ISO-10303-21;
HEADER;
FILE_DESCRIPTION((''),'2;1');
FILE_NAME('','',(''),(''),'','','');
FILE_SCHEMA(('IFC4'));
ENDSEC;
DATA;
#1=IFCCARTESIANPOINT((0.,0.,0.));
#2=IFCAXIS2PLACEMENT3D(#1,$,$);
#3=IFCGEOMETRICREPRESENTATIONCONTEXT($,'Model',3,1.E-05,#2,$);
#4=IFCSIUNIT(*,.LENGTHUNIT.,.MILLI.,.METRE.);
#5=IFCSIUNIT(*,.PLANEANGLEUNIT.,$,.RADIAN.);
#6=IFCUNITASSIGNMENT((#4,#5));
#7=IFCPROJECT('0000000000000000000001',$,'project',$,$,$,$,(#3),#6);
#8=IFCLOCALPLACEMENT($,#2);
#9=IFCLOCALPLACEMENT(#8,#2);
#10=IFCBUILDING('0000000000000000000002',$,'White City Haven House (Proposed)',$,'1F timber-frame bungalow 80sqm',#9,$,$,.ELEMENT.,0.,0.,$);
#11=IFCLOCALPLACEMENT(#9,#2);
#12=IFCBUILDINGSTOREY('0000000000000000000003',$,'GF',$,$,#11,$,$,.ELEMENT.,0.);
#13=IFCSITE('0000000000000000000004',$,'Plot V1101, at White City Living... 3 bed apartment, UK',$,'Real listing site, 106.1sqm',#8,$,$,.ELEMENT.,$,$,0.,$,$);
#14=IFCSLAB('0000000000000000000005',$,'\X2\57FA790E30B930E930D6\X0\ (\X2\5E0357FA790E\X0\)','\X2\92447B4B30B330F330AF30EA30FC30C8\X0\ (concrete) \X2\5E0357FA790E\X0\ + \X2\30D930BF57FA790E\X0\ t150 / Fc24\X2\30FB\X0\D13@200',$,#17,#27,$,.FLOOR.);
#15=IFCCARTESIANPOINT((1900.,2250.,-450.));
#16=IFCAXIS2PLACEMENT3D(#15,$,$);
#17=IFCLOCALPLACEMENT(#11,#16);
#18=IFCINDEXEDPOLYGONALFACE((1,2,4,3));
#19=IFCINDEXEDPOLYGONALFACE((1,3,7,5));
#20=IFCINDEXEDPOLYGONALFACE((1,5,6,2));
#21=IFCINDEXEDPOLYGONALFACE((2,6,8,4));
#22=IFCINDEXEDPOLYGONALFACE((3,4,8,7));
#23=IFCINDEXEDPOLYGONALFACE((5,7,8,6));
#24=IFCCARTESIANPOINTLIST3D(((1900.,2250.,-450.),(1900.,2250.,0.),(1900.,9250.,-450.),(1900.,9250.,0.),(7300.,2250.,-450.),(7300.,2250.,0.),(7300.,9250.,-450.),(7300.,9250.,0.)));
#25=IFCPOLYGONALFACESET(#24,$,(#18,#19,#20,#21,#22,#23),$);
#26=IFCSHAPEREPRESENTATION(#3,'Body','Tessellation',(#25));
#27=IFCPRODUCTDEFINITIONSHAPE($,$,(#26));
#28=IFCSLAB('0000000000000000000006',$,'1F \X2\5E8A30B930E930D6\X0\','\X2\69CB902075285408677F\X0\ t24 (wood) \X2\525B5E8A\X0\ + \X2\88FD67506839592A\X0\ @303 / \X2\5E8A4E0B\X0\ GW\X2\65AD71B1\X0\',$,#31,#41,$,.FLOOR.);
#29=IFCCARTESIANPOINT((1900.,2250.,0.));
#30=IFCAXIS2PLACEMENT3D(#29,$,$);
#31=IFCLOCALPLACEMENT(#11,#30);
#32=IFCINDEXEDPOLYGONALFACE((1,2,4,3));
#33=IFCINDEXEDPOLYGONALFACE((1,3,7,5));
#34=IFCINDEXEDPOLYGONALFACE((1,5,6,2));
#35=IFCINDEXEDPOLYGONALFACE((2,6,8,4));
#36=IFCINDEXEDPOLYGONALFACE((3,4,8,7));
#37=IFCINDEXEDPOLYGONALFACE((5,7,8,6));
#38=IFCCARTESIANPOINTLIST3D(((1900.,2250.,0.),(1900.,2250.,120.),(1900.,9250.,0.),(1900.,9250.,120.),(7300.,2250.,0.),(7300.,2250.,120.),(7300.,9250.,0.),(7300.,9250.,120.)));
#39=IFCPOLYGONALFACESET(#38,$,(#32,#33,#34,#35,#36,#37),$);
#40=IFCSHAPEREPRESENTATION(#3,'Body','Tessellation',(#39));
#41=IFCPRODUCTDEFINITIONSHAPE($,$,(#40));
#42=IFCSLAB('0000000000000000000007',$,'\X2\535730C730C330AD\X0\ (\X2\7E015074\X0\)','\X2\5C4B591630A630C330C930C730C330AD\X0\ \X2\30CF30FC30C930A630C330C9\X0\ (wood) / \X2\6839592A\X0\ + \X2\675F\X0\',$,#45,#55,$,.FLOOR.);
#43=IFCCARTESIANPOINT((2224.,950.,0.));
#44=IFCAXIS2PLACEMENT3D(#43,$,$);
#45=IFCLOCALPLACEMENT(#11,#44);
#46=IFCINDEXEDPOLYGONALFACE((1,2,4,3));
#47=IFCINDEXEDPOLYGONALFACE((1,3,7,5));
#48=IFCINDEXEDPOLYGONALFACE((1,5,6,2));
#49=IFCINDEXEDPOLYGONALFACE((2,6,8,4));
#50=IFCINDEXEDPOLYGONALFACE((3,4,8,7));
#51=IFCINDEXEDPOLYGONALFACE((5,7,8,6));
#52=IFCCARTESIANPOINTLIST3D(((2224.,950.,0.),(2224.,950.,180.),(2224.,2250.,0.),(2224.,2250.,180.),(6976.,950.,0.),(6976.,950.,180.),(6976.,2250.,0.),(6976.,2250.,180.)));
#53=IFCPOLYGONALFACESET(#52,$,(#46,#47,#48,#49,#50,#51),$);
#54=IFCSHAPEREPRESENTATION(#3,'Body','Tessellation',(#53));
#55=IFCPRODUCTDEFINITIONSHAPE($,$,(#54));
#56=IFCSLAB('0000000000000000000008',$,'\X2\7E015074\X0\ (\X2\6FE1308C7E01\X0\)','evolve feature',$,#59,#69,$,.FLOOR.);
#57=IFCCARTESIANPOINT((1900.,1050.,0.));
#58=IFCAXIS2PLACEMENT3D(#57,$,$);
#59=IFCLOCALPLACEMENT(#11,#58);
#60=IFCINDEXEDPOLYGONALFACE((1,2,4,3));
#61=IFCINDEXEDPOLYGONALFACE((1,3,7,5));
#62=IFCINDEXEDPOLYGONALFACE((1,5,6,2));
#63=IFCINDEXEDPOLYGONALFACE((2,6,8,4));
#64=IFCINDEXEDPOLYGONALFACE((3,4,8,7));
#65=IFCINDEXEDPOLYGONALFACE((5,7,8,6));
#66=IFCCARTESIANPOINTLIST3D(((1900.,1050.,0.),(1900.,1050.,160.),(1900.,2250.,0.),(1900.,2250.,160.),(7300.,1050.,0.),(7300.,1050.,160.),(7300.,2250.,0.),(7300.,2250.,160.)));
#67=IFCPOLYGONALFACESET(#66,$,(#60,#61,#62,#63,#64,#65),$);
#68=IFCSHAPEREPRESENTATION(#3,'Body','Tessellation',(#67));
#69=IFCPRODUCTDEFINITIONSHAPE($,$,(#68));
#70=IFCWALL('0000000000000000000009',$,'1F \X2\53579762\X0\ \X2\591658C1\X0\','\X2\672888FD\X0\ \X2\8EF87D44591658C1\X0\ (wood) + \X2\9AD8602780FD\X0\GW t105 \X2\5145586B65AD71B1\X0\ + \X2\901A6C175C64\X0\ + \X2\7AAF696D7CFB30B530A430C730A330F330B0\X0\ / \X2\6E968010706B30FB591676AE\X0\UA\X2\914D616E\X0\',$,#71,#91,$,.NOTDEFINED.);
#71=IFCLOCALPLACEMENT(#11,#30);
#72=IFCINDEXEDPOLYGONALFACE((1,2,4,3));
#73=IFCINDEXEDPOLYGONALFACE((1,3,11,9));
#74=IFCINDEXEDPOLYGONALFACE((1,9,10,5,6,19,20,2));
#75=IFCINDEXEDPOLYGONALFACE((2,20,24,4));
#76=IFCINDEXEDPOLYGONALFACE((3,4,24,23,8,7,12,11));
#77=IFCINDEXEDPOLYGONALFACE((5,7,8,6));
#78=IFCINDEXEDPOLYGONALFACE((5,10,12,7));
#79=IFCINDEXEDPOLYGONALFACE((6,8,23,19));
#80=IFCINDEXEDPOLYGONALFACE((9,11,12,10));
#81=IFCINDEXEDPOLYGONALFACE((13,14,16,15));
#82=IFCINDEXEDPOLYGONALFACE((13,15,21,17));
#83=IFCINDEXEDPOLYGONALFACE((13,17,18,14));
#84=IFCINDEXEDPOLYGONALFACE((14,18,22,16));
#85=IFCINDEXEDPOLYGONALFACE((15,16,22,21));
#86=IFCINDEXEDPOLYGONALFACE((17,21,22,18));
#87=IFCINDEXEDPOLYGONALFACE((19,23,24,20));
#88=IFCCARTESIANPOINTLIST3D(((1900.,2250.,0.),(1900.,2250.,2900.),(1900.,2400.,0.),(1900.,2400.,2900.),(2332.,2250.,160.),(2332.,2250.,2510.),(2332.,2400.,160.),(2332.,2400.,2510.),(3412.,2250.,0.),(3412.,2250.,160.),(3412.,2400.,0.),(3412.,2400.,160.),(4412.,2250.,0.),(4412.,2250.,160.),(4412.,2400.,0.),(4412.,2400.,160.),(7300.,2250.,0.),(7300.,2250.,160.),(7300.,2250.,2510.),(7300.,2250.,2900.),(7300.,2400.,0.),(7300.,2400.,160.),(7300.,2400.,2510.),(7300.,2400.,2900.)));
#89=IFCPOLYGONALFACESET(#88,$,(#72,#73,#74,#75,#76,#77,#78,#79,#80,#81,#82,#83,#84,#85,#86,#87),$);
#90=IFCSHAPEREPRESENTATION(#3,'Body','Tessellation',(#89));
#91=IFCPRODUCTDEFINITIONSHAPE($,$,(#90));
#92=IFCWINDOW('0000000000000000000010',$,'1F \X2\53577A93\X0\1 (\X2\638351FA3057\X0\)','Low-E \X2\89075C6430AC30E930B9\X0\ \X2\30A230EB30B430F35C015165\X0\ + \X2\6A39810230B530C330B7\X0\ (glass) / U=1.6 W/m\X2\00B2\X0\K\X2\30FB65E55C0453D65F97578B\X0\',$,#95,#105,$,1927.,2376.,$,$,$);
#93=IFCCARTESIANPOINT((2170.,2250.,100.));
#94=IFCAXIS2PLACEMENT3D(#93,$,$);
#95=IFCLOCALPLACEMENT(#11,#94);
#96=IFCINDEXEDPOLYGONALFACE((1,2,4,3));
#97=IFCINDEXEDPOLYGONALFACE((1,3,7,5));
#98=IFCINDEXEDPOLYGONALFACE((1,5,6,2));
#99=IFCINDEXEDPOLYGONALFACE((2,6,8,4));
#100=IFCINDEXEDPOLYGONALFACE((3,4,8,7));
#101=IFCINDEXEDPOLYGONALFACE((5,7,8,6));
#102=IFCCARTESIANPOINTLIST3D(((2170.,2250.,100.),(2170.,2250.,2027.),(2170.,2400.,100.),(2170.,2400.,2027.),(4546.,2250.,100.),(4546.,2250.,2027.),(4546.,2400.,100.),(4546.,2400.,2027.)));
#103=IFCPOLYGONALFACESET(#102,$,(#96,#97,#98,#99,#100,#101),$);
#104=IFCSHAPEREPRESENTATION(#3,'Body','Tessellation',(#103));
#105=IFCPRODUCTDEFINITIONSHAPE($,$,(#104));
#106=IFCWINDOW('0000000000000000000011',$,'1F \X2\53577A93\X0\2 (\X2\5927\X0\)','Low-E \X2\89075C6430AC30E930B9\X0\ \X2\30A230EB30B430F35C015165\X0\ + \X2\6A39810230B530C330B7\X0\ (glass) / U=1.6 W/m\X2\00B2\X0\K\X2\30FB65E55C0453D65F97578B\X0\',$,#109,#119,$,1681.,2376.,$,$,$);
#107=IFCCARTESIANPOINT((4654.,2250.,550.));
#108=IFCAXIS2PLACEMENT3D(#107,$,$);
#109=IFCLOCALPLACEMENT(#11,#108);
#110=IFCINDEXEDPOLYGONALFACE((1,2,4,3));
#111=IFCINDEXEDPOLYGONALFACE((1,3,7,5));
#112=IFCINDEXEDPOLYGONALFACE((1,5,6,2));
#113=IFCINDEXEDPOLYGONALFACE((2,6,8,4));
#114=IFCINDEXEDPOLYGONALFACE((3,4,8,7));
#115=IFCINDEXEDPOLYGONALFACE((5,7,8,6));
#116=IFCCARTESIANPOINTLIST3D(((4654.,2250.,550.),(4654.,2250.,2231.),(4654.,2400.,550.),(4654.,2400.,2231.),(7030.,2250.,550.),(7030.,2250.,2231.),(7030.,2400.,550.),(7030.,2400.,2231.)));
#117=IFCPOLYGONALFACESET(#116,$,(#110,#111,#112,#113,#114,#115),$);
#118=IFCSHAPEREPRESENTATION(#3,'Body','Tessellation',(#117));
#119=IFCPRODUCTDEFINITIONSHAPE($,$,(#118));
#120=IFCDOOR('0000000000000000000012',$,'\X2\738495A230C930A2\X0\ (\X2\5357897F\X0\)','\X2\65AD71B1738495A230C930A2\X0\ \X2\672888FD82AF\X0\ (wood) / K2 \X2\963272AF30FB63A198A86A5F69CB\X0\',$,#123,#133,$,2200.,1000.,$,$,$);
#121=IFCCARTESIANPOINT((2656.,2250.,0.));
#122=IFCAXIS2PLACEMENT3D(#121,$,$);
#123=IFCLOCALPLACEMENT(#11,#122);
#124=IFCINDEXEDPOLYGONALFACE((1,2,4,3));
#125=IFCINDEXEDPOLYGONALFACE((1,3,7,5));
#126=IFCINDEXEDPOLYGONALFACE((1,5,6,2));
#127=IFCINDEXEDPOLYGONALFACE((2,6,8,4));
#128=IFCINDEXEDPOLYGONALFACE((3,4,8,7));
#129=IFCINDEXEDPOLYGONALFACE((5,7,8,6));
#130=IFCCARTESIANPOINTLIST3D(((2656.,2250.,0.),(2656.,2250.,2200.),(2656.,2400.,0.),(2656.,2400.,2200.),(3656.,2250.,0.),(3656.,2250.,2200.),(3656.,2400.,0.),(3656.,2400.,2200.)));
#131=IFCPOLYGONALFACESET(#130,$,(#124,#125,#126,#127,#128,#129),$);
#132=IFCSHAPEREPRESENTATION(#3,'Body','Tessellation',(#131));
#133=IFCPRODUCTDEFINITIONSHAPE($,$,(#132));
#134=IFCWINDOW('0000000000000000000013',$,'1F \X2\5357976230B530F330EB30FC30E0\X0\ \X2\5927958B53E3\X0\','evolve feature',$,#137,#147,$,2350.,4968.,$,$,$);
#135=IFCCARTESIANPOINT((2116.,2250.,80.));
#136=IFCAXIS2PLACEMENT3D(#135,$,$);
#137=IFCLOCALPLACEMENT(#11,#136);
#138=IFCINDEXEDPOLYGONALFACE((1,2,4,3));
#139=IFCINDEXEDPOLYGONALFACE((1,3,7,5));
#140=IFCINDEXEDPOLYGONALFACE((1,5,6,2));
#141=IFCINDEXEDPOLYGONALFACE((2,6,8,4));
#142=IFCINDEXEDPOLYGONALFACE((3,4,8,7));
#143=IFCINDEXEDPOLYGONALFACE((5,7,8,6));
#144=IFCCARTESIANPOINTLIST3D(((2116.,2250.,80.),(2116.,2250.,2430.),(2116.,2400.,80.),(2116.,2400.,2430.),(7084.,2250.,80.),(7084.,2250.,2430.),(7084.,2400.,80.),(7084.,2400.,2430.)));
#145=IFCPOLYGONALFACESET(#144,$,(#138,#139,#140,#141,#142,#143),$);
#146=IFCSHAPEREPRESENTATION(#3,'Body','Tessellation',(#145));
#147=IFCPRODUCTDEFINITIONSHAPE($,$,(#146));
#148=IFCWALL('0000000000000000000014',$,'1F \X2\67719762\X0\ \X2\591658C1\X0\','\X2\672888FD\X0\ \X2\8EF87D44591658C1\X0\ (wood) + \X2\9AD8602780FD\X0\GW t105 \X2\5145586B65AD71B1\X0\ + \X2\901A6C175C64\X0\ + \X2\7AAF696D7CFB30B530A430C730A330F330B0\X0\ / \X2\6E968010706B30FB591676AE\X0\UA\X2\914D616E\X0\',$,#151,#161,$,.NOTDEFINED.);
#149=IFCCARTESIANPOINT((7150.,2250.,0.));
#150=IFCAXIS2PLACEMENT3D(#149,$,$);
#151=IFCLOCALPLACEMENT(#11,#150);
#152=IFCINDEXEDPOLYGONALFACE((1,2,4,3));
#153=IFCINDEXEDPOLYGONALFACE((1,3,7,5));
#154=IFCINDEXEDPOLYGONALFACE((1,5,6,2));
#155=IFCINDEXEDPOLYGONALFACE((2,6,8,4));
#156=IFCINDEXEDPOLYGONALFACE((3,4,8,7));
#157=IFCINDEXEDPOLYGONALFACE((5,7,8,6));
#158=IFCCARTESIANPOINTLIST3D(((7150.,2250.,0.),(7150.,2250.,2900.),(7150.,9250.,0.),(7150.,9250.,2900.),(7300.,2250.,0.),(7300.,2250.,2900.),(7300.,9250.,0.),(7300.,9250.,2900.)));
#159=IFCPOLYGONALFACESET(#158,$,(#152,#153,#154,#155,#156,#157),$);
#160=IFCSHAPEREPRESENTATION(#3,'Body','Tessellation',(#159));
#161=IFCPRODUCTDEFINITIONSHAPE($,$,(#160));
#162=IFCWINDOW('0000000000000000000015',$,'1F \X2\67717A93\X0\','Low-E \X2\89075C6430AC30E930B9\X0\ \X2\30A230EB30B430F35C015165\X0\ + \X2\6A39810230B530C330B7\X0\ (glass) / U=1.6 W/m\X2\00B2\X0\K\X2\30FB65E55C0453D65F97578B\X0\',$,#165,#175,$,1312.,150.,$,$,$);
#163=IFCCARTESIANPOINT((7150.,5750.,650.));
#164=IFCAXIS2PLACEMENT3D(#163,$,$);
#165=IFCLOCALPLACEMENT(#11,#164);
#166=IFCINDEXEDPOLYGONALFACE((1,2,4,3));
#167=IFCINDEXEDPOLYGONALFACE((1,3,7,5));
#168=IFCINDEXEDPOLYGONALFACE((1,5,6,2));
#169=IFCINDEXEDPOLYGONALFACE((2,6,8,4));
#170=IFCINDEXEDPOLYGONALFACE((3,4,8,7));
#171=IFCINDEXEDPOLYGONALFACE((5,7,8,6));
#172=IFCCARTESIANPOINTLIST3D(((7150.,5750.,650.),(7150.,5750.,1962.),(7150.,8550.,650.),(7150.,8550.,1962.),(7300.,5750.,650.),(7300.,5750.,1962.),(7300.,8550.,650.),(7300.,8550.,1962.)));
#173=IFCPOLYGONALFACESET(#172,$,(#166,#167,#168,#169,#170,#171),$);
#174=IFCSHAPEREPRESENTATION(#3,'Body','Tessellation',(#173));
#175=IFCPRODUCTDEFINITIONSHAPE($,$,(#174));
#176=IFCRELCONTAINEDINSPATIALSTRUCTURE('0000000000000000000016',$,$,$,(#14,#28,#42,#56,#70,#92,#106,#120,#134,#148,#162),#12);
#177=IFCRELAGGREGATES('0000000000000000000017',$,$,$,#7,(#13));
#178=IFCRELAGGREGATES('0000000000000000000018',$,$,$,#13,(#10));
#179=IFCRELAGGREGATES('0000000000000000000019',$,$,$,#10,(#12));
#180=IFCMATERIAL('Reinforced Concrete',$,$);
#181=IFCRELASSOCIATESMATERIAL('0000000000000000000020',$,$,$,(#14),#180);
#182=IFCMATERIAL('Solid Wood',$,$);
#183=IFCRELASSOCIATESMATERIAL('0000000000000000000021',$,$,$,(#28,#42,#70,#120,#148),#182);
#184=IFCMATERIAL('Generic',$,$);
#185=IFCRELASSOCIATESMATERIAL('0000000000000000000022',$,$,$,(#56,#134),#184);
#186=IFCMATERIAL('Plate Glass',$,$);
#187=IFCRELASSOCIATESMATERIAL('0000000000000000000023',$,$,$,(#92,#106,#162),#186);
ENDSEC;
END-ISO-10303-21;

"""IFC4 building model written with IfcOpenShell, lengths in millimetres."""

from ifc_helpers import new_model, si_unit, frame, frame_2d, origin, place, context, project, spatial, rectangle, extrude, material, element, fill, save


model = new_model("IFC4")

# Units and contexts
model_context = context("Model", 3, precision=1e-05, world=origin())
ifc_project = project(units=[si_unit("LENGTHUNIT", "METRE", prefix="MILLI"), si_unit("PLANEANGLEUNIT", "RADIAN")], contexts=[model_context])

# Site, building, storey
site_placement = place(None, origin())
site = spatial("IfcSite", under=ifc_project, at=site_placement, Name="Plot V1101, at White City Living... 3 bed apartment, UK", ObjectType="Real listing site, 106.1sqm", CompositionType="ELEMENT", RefElevation=0.0)
building_placement = place(site_placement, origin())
building = spatial("IfcBuilding", under=site, at=building_placement, Name="White City Haven House (Proposed)", ObjectType="1F timber-frame bungalow 80sqm", CompositionType="ELEMENT", ElevationOfRefHeight=0.0, ElevationOfTerrain=0.0)
storey_placement = place(building_placement, origin())
storey = spatial("IfcBuildingStorey", under=building, at=storey_placement, Name="GF", CompositionType="ELEMENT", Elevation=0.0)

# Slabs
ifc_material_1 = material(Name="Reinforced Concrete")
slab_1_placement = place(storey_placement, frame((1900.0, 2250.0, -450.0)))
element("IfcSlab", 1, at=slab_1_placement, inside=storey, material=ifc_material_1, Name="基礎スラブ (布基礎)", Description="鉄筋コンクリート (concrete) 布基礎 + ベタ基礎 t150 / Fc24・D13@200", PredefinedType="FLOOR", context=model_context, shape_type="SweptSolid", body=[
    extrude(rectangle(XDim=5400.0, YDim=7000.0, at=frame_2d((2700.0, 3500.0))), frame((1900.0, 2250.0, -450.0)), (0.0, 0.0, 1.0), 450.0),
])
ifc_material_2 = material(Name="Solid Wood")
slab_2_placement = place(storey_placement, frame((1900.0, 2250.0, 0.0)))
element("IfcSlab", 2, at=slab_2_placement, inside=storey, material=ifc_material_2, Name="1F 床スラブ", Description="構造用合板 t24 (wood) 剛床 + 製材根太 @303 / 床下 GW断熱", PredefinedType="FLOOR", context=model_context, shape_type="SweptSolid", body=[
    extrude(rectangle(XDim=5400.0, YDim=7000.0, at=frame_2d((2700.0, 3500.0))), frame((1900.0, 2250.0, 0.0)), (0.0, 0.0, 1.0), 120.0),
])
slab_3_placement = place(storey_placement, frame((2224.0, 950.0, 0.0)))
element("IfcSlab", 3, at=slab_3_placement, inside=storey, material=ifc_material_2, Name="南デッキ (縁側)", Description="屋外ウッドデッキ ハードウッド (wood) / 根太 + 束", PredefinedType="FLOOR", context=model_context, shape_type="SweptSolid", body=[
    extrude(rectangle(XDim=4752.0, YDim=1300.0, at=frame_2d((2376.0, 650.0))), frame((2224.0, 950.0, 0.0)), (0.0, 0.0, 1.0), 180.0),
])
ifc_material_3 = material(Name="Generic")
slab_4_placement = place(storey_placement, frame((1900.0, 1050.0, 0.0)))
element("IfcSlab", 4, at=slab_4_placement, inside=storey, material=ifc_material_3, Name="縁側 (濡れ縁)", Description="evolve feature", PredefinedType="FLOOR", context=model_context, shape_type="SweptSolid", body=[
    extrude(rectangle(XDim=5400.0, YDim=1200.0, at=frame_2d((2700.0, 600.0))), frame((1900.0, 1050.0, 0.0)), (0.0, 0.0, 1.0), 160.0),
])

# Wall, openings, windows, door
wall_1_placement = place(storey_placement, frame((1900.0, 2250.0, 0.0)))
wall_1 = element("IfcWall", 5, at=wall_1_placement, inside=storey, material=ifc_material_2, Name="1F 南面 外壁", Description="木製 軸組外壁 (wood) + 高性能GW t105 充填断熱 + 通気層 + 窯業系サイディング / 準耐火・外皮UA配慮", PredefinedType="NOTDEFINED", context=model_context, shape_type="SweptSolid", body=[
    extrude(rectangle(XDim=5400.0, YDim=150.0, at=frame_2d((2700.0, 75.0))), frame((1900.0, 2250.0, 0.0)), (0.0, 0.0, 1.0), 2900.0),
])
opening_1_placement = place(storey_placement, frame((2170.0, 2250.0, 100.0)))
opening_1 = element("IfcOpeningElement", 6, at=opening_1_placement, cuts=wall_1, PredefinedType="NOTDEFINED", context=model_context, shape_type="SweptSolid", body=[
    extrude(rectangle(XDim=2376.0, YDim=150.0, at=frame_2d((1188.0, 75.0))), frame((2170.0, 2250.0, 100.0)), (0.0, 0.0, 1.0), 1927.0),
])
opening_2_placement = place(storey_placement, frame((4654.0, 2250.0, 550.0)))
opening_2 = element("IfcOpeningElement", 7, at=opening_2_placement, cuts=wall_1, PredefinedType="NOTDEFINED", context=model_context, shape_type="SweptSolid", body=[
    extrude(rectangle(XDim=2376.0, YDim=150.0, at=frame_2d((1188.0, 75.0))), frame((4654.0, 2250.0, 550.0)), (0.0, 0.0, 1.0), 1681.0),
])
opening_3_placement = place(storey_placement, frame((2656.0, 2250.0, 0.0)))
opening_3 = element("IfcOpeningElement", 8, at=opening_3_placement, cuts=wall_1, PredefinedType="NOTDEFINED", context=model_context, shape_type="SweptSolid", body=[
    extrude(rectangle(XDim=1000.0, YDim=150.0, at=frame_2d((500.0, 75.0))), frame((2656.0, 2250.0, 0.0)), (0.0, 0.0, 1.0), 2200.0),
])
opening_4_placement = place(storey_placement, frame((2116.0, 2250.0, 80.0)))
opening_4 = element("IfcOpeningElement", 9, at=opening_4_placement, cuts=wall_1, PredefinedType="NOTDEFINED", context=model_context, shape_type="SweptSolid", body=[
    extrude(rectangle(XDim=4968.0, YDim=150.0, at=frame_2d((2484.0, 75.0))), frame((2116.0, 2250.0, 80.0)), (0.0, 0.0, 1.0), 2350.0),
])
ifc_material_4 = material(Name="Plate Glass")
window_1_placement = place(storey_placement, frame((2170.0, 2250.0, 100.0)))
window_1 = element("IfcWindow", 10, at=window_1_placement, inside=storey, material=ifc_material_4, Name="1F 南窓1 (掃出し)", Description="Low-E 複層ガラス アルゴン封入 + 樹脂サッシ (glass) / U=1.6 W/m²K・日射取得型", OverallHeight=1927.0, OverallWidth=2376.0, context=model_context, shape_type="SweptSolid", body=[
    extrude(rectangle(XDim=2376.0, YDim=150.0, at=frame_2d((1188.0, 75.0))), frame((2170.0, 2250.0, 100.0)), (0.0, 0.0, 1.0), 1927.0),
])
fill(opening_1, window_1)
window_2_placement = place(storey_placement, frame((4654.0, 2250.0, 550.0)))
window_2 = element("IfcWindow", 11, at=window_2_placement, inside=storey, material=ifc_material_4, Name="1F 南窓2 (大)", Description="Low-E 複層ガラス アルゴン封入 + 樹脂サッシ (glass) / U=1.6 W/m²K・日射取得型", OverallHeight=1681.0, OverallWidth=2376.0, context=model_context, shape_type="SweptSolid", body=[
    extrude(rectangle(XDim=2376.0, YDim=150.0, at=frame_2d((1188.0, 75.0))), frame((4654.0, 2250.0, 550.0)), (0.0, 0.0, 1.0), 1681.0),
])
fill(opening_2, window_2)
door_placement = place(storey_placement, frame((2656.0, 2250.0, 0.0)))
door = element("IfcDoor", 12, at=door_placement, inside=storey, material=ifc_material_2, Name="玄関ドア (南西)", Description="断熱玄関ドア 木製芯 (wood) / K2 防犯・採風機構", OverallHeight=2200.0, OverallWidth=1000.0, context=model_context, shape_type="SweptSolid", body=[
    extrude(rectangle(XDim=1000.0, YDim=150.0, at=frame_2d((500.0, 75.0))), frame((2656.0, 2250.0, 0.0)), (0.0, 0.0, 1.0), 2200.0),
])
fill(opening_3, door)
window_3_placement = place(storey_placement, frame((2116.0, 2250.0, 80.0)))
window_3 = element("IfcWindow", 13, at=window_3_placement, inside=storey, material=ifc_material_3, Name="1F 南面サンルーム 大開口", Description="evolve feature", OverallHeight=2350.0, OverallWidth=4968.0, context=model_context, shape_type="SweptSolid", body=[
    extrude(rectangle(XDim=4968.0, YDim=150.0, at=frame_2d((2484.0, 75.0))), frame((2116.0, 2250.0, 80.0)), (0.0, 0.0, 1.0), 2350.0),
])
fill(opening_4, window_3)

# Wall, opening, window
wall_2_placement = place(storey_placement, frame((7150.0, 2250.0, 0.0)))
wall_2 = element("IfcWall", 14, at=wall_2_placement, inside=storey, material=ifc_material_2, Name="1F 東面 外壁", Description="木製 軸組外壁 (wood) + 高性能GW t105 充填断熱 + 通気層 + 窯業系サイディング / 準耐火・外皮UA配慮", PredefinedType="NOTDEFINED", context=model_context, shape_type="SweptSolid", body=[
    extrude(rectangle(XDim=150.0, YDim=7000.0, at=frame_2d((75.0, 3500.0))), frame((7150.0, 2250.0, 0.0)), (0.0, 0.0, 1.0), 2900.0),
])
opening_5_placement = place(storey_placement, frame((7150.0, 5750.0, 650.0)))
opening_5 = element("IfcOpeningElement", 15, at=opening_5_placement, cuts=wall_2, PredefinedType="NOTDEFINED", context=model_context, shape_type="SweptSolid", body=[
    extrude(rectangle(XDim=150.0, YDim=2800.0, at=frame_2d((75.0, 1400.0))), frame((7150.0, 5750.0, 650.0)), (0.0, 0.0, 1.0), 1312.0),
])
window_4_placement = place(storey_placement, frame((7150.0, 5750.0, 650.0)))
window_4 = element("IfcWindow", 16, at=window_4_placement, inside=storey, material=ifc_material_4, Name="1F 東窓", Description="Low-E 複層ガラス アルゴン封入 + 樹脂サッシ (glass) / U=1.6 W/m²K・日射取得型", OverallHeight=1312.0, OverallWidth=150.0, context=model_context, shape_type="SweptSolid", body=[
    extrude(rectangle(XDim=150.0, YDim=2800.0, at=frame_2d((75.0, 1400.0))), frame((7150.0, 5750.0, 650.0)), (0.0, 0.0, 1.0), 1312.0),
])
fill(opening_5, window_4)

save(model, "model.ifc")
